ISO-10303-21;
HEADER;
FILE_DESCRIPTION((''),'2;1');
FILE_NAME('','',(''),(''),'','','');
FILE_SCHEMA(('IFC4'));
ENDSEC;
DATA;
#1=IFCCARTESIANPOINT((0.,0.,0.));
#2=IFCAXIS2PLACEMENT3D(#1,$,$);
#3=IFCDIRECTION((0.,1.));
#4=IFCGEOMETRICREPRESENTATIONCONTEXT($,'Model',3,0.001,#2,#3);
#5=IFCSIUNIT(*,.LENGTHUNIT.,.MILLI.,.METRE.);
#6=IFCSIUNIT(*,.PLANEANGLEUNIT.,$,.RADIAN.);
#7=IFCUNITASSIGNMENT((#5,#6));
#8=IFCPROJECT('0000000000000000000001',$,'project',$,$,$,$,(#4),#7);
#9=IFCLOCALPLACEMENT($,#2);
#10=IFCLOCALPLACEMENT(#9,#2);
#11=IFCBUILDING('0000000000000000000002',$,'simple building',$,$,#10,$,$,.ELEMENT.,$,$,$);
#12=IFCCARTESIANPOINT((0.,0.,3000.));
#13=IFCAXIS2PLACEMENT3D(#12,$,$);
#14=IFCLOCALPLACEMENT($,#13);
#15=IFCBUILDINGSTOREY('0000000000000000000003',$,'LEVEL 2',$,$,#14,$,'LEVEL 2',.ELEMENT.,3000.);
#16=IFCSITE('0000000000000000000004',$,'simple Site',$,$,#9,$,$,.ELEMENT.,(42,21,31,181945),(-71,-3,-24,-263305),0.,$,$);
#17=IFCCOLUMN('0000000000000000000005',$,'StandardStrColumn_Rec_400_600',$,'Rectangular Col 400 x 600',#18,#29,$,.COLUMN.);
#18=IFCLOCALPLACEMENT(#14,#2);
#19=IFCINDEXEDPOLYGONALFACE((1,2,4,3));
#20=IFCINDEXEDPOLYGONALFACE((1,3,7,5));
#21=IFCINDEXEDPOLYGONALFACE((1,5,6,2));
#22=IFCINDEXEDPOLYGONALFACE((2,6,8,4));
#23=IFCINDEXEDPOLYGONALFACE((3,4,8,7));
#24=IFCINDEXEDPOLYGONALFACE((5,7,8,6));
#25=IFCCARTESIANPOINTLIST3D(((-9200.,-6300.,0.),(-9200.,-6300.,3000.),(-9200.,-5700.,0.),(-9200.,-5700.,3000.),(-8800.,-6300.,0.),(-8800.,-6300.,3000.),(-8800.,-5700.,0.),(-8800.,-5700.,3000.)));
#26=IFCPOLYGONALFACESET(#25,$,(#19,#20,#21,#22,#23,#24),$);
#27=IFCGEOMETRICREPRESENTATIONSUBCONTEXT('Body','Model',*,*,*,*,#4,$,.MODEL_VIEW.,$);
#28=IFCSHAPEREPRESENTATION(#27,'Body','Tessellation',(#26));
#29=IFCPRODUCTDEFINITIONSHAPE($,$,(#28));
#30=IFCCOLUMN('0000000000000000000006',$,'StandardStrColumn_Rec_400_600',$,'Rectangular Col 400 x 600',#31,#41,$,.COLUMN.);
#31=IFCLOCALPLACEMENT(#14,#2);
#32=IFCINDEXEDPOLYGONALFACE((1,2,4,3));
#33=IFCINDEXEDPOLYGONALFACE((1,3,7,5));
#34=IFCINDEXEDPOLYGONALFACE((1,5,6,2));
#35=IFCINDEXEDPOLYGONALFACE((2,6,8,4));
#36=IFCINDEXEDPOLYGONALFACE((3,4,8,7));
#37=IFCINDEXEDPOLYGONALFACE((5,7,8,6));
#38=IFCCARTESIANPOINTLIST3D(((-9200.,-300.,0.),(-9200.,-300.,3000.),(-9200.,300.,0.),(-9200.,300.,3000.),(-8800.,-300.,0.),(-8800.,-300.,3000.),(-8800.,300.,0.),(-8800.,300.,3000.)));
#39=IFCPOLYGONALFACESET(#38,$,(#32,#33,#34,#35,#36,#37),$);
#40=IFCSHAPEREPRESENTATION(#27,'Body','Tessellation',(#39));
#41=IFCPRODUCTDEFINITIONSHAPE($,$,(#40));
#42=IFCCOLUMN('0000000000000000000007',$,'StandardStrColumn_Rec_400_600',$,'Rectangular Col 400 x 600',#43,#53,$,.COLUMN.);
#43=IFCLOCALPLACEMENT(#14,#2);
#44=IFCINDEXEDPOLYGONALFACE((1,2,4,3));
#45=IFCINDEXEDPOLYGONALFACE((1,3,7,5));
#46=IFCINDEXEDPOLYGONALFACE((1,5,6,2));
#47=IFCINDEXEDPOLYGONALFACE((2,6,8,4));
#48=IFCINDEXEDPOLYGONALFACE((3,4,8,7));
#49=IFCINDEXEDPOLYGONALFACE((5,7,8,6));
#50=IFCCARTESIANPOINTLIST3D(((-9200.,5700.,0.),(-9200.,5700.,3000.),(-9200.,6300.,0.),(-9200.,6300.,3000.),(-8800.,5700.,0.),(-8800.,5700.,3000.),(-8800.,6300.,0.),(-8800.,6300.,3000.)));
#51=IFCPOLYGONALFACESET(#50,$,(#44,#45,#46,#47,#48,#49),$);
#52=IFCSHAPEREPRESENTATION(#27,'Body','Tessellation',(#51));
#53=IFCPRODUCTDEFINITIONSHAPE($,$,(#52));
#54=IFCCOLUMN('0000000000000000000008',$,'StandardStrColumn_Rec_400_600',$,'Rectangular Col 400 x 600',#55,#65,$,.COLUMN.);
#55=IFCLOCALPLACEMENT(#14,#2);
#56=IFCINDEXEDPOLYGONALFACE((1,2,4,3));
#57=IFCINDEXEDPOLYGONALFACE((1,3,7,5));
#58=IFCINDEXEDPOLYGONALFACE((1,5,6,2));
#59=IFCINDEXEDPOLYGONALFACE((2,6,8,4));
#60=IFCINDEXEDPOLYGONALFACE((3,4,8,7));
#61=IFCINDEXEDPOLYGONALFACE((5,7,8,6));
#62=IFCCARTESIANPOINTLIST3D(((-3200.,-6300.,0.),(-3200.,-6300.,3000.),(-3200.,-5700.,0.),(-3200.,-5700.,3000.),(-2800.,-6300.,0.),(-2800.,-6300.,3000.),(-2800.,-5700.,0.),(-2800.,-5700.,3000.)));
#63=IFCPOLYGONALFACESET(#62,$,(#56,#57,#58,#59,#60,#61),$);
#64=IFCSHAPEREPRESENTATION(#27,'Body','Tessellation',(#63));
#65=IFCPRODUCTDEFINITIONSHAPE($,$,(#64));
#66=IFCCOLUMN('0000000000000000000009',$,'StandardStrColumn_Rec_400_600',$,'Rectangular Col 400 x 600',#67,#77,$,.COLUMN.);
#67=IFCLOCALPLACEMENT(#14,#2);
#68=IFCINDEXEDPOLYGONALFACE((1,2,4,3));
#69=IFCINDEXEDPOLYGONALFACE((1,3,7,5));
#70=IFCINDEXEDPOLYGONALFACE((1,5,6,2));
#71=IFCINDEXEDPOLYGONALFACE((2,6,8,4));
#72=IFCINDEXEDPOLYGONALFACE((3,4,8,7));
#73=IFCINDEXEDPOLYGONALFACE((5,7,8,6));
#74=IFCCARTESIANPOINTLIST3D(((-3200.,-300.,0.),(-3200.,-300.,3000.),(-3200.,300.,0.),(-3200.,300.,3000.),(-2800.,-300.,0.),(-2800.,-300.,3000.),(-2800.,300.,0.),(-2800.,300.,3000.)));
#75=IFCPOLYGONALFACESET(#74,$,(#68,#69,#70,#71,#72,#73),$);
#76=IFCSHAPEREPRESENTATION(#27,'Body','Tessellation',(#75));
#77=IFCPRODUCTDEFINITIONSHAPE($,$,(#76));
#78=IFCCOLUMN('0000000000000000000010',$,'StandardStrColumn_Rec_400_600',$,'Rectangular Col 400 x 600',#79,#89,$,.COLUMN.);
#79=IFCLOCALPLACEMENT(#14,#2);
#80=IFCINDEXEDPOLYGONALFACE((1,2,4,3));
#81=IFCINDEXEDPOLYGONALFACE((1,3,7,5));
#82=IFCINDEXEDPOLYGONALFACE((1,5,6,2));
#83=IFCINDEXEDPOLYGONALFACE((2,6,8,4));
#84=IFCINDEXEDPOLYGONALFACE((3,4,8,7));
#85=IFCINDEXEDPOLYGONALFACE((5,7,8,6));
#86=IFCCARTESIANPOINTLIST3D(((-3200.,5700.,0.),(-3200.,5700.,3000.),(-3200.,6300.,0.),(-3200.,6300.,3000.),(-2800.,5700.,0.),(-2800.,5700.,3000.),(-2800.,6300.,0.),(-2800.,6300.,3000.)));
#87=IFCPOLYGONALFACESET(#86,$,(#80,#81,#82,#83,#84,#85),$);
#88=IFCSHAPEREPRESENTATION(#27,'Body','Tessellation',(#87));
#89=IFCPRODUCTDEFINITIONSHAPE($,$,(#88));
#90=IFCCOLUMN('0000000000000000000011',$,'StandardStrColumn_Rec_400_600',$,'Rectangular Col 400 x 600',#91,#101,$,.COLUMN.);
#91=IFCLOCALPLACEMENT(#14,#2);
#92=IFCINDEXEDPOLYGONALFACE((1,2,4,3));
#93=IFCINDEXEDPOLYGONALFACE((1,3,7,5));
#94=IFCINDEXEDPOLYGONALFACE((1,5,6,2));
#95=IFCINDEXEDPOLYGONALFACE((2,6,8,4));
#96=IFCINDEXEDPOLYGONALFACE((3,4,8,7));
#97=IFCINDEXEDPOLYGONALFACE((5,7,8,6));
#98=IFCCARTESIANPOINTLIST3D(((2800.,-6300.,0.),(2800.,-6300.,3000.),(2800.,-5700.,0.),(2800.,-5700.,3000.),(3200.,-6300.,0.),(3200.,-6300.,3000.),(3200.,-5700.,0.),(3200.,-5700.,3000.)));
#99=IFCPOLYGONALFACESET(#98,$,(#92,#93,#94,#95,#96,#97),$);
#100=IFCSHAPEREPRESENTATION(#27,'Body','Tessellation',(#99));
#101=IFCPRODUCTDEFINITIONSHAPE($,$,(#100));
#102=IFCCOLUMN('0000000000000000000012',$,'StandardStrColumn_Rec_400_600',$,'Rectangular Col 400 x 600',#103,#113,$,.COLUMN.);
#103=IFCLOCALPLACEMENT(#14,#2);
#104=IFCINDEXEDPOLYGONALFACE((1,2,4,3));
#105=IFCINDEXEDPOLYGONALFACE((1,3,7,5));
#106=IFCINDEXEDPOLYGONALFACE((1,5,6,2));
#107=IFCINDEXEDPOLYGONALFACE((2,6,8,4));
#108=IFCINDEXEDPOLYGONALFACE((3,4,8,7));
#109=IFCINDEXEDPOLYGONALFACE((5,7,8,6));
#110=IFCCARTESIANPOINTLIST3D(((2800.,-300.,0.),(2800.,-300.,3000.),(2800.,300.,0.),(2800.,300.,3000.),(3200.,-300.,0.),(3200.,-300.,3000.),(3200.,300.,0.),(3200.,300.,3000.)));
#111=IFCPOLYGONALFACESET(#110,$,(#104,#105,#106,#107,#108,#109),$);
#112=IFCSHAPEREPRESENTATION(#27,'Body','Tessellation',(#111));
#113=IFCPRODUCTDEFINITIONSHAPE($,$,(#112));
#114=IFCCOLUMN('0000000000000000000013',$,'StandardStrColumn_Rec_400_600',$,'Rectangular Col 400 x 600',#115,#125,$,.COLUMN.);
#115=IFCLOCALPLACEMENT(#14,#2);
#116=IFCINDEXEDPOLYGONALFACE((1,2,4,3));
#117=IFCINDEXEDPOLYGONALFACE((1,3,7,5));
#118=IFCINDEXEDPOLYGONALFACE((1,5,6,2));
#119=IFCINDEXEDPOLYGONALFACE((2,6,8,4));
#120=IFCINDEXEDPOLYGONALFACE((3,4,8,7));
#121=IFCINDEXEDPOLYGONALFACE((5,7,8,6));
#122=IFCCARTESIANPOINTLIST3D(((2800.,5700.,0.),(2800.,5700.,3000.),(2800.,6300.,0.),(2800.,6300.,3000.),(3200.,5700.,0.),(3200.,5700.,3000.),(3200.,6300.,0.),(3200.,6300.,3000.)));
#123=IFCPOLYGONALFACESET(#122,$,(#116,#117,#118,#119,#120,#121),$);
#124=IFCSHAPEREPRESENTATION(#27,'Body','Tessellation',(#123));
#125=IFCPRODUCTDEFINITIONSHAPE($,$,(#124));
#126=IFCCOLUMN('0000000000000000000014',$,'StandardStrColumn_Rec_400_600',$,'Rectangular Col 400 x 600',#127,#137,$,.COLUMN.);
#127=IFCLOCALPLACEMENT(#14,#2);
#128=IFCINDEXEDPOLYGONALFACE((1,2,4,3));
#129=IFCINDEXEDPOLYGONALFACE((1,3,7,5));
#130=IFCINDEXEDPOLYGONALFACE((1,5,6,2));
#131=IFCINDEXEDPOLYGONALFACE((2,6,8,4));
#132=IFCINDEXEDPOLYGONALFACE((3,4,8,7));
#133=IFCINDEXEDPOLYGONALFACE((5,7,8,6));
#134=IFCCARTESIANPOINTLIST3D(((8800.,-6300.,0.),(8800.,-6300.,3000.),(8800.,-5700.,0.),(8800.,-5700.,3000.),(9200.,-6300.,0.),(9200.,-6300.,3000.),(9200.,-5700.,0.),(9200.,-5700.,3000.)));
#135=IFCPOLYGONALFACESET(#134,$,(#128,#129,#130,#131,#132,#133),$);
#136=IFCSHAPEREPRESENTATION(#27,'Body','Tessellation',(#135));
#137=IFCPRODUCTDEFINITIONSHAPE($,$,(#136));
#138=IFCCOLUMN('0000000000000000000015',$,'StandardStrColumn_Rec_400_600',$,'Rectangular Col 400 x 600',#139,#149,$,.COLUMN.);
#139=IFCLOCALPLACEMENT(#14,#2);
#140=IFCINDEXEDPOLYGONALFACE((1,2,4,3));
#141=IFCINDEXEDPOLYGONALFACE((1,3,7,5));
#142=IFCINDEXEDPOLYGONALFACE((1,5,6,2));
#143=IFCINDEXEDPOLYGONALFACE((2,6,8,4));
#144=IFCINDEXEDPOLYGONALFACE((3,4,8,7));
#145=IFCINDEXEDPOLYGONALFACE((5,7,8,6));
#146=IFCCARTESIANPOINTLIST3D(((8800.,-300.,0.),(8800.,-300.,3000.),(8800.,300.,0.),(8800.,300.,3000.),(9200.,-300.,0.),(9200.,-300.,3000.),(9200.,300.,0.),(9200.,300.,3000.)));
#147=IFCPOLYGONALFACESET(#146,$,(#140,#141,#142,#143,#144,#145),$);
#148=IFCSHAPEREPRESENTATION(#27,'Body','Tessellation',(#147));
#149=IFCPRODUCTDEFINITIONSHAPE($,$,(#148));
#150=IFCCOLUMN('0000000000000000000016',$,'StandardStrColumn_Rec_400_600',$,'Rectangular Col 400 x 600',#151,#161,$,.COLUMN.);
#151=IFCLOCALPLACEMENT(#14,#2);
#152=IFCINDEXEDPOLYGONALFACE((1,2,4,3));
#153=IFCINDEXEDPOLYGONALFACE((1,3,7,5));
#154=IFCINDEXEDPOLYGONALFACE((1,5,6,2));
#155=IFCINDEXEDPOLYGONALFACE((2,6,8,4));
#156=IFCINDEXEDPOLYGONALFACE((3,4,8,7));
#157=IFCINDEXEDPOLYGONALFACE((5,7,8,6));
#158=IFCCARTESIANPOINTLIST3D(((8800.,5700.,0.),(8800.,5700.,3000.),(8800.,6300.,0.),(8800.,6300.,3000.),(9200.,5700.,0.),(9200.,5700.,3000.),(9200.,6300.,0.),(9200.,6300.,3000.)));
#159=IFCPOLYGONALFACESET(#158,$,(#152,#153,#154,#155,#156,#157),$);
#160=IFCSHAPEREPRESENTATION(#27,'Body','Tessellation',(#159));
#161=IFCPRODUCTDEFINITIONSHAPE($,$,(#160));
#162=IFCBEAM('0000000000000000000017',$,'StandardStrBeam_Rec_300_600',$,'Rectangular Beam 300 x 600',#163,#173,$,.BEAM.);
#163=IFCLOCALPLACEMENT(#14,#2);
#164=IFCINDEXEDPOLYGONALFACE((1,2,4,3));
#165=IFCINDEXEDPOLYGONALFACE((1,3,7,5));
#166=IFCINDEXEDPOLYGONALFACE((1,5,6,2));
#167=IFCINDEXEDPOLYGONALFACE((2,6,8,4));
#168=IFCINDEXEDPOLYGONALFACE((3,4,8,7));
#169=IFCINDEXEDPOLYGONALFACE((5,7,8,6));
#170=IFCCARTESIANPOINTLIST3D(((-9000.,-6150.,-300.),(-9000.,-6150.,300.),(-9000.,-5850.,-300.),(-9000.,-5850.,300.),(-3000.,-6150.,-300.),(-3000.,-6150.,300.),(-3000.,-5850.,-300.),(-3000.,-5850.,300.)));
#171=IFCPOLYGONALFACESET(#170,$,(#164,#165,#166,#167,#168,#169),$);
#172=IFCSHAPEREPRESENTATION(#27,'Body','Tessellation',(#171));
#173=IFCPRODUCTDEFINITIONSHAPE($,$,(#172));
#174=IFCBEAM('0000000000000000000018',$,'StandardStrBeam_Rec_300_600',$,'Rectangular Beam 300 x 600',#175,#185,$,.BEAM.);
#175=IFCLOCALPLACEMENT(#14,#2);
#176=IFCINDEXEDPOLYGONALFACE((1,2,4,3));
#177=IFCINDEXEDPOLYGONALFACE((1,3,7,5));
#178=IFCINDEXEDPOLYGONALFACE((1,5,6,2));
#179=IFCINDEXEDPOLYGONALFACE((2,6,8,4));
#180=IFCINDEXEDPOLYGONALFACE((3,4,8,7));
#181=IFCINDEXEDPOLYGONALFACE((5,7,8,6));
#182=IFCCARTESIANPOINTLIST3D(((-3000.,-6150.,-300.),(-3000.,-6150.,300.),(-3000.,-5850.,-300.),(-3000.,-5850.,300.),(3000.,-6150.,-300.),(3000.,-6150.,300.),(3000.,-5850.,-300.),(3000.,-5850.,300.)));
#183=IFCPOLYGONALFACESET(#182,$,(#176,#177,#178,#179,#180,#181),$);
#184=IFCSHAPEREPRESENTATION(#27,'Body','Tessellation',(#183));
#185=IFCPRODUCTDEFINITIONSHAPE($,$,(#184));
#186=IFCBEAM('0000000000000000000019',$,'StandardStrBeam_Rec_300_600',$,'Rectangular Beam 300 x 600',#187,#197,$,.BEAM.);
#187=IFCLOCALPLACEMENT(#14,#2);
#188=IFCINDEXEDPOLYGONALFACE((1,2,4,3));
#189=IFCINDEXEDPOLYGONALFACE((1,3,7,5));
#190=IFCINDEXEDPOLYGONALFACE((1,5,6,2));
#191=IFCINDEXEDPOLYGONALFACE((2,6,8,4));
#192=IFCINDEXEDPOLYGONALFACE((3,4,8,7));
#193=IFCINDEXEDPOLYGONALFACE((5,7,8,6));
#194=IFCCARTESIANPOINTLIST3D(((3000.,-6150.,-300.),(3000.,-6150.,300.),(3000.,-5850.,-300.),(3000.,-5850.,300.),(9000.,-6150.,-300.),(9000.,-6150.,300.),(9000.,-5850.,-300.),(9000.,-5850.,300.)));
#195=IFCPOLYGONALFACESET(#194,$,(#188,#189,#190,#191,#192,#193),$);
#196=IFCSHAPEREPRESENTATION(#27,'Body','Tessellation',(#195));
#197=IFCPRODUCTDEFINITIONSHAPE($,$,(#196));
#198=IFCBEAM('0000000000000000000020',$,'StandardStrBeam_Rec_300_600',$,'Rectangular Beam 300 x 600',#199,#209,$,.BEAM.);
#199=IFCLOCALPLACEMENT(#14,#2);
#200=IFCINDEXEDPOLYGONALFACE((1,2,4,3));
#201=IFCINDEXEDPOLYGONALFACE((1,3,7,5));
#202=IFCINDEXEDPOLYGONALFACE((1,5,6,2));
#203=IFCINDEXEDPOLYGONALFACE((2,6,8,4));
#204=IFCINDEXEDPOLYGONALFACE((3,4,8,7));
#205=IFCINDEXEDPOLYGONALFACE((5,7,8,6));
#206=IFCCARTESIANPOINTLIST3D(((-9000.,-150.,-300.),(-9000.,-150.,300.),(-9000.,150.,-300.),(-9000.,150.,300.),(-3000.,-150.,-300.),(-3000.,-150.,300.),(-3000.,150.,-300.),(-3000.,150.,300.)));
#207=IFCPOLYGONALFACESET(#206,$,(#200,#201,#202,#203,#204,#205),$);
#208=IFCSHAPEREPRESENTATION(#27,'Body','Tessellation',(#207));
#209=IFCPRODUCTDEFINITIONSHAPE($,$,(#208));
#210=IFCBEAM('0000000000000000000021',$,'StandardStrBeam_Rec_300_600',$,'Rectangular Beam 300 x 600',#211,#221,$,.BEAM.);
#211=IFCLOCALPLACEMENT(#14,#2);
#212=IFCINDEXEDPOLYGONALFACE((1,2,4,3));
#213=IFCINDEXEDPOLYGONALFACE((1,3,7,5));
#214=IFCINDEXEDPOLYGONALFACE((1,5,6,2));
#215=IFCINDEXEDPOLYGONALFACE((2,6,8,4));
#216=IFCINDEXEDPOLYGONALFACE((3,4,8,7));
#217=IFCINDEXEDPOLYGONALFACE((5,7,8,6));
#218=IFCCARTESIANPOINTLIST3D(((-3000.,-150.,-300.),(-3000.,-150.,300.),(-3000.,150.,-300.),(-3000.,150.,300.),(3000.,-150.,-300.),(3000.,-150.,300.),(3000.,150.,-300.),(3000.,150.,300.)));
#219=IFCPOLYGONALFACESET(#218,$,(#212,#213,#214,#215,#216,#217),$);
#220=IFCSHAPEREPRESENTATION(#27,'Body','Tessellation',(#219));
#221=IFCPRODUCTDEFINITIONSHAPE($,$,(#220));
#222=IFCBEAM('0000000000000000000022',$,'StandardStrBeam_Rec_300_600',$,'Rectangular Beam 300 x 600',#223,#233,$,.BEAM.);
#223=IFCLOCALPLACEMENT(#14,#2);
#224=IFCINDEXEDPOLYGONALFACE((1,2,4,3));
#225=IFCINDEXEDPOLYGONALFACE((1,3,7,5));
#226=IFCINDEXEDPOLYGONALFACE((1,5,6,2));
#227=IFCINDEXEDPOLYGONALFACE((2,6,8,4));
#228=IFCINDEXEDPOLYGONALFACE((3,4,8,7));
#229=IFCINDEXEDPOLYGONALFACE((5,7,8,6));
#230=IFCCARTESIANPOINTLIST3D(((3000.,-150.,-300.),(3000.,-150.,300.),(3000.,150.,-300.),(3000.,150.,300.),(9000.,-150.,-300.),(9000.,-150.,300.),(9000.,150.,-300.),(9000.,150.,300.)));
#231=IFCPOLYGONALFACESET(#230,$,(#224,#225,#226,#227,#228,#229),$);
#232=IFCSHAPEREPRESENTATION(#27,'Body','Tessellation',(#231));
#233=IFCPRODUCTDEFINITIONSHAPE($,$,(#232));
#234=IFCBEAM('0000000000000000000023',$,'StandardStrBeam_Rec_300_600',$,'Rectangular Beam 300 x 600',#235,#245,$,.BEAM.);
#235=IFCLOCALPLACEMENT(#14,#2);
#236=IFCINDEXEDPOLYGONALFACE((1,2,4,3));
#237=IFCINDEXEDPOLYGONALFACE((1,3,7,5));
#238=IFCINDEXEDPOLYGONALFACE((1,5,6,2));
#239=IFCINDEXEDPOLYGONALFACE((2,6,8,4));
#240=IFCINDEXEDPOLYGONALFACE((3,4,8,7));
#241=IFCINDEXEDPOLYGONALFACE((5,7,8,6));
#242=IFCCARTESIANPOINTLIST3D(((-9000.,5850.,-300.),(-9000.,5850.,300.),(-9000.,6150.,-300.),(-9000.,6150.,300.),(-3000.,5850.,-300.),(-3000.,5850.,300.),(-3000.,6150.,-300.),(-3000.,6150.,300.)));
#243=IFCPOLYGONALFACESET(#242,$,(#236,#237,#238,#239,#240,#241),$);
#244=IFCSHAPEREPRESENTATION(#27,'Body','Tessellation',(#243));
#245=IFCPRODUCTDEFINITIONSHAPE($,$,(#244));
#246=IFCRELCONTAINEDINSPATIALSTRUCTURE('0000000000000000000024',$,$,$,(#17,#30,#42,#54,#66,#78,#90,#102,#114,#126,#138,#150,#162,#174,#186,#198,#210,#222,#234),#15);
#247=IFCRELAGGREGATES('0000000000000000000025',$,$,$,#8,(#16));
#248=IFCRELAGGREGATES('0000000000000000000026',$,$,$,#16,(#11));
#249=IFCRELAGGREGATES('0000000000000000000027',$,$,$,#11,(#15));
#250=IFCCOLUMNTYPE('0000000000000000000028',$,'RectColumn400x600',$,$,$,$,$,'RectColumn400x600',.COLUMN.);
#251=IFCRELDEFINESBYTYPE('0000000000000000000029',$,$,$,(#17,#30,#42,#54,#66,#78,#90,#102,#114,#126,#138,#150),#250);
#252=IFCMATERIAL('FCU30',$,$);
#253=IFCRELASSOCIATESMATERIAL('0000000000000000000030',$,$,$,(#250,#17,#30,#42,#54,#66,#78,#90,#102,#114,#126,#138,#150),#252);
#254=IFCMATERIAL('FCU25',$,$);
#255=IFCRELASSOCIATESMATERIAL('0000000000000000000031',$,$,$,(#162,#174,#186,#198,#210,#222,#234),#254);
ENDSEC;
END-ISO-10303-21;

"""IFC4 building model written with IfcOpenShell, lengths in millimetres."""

from ifc_helpers import new_model, si_unit, direction, frame, origin, origin_with_axes, origin_2d_with_axis, place, context, subcontext, project, spatial, rectangle, extrude, material, material_profile, profile_set, profile_usage, type_object, element, save


model = new_model("IFC4")

# Units and contexts
model_context = context("Model", 3, precision=0.001, world=origin(), true_north=direction((0.0, 1.0)))
body_context = subcontext(model_context, "Body", "Model", "MODEL_VIEW")
ifc_project = project(units=[si_unit("LENGTHUNIT", "METRE", prefix="MILLI"), si_unit("PLANEANGLEUNIT", "RADIAN")], contexts=[model_context])

# Site, building, storey
site_placement = place(None, origin())
site = spatial("IfcSite", under=ifc_project, at=site_placement, Name="simple Site", CompositionType="ELEMENT", RefLatitude=(42, 21, 31, 181945), RefLongitude=(-71, -3, -24, -263305), RefElevation=0.0)
building_placement = place(site_placement, origin())
building = spatial("IfcBuilding", under=site, at=building_placement, Name="simple building", CompositionType="ELEMENT")
storey_placement = place(None, frame((0.0, 0.0, 3000.0)))
storey = spatial("IfcBuildingStorey", under=building, at=storey_placement, Name="LEVEL 2", LongName="LEVEL 2", CompositionType="ELEMENT", Elevation=3000.0)

# Columns
ifc_material_1 = material(Name="FCU30")
ifc_material_profile_1 = material_profile(ifc_material_1, rectangle(XDim=400.0, YDim=600.0, at=origin_2d_with_axis()))
ifc_profile_set_1 = profile_set([ifc_material_profile_1])
ifc_profile_usage_1 = profile_usage(ifc_profile_set_1, cardinal=10)
column_type = type_object("IfcColumnType", Name="RectColumn400x600", ElementType="RectColumn400x600", PredefinedType="COLUMN", material=ifc_profile_usage_1)
for number, where, z_axis, x_axis, name in (
    (1, (-9000.0, -6000.0, 3000.0), (0.0, 0.0, 1.0), (1.0, 0.0, 0.0), "StandardStrColumn_Rec_400_600"),
    (2, (-9000.0, 0.0, 3000.0), (0.0, 0.0, 1.0), (1.0, 0.0, 0.0), "StandardStrColumn_Rec_400_600"),
    (3, (-9000.0, 6000.0, 3000.0), (0.0, 0.0, 1.0), (1.0, 0.0, 0.0), "StandardStrColumn_Rec_400_600"),
    (4, (-3000.0, -6000.0, 3000.0), (0.0, 0.0, 1.0), (1.0, 0.0, 0.0), "StandardStrColumn_Rec_400_600"),
    (5, (-3000.0, 0.0, 3000.0), (0.0, 0.0, 1.0), (1.0, 0.0, 0.0), "StandardStrColumn_Rec_400_600"),
    (6, (-3000.0, 6000.0, 3000.0), (0.0, 0.0, 1.0), (1.0, 0.0, 0.0), "StandardStrColumn_Rec_400_600"),
    (7, (3000.0, -6000.0, 3000.0), (0.0, 0.0, 1.0), (1.0, 0.0, 0.0), "StandardStrColumn_Rec_400_600"),
    (8, (3000.0, 0.0, 3000.0), (0.0, 0.0, 1.0), (1.0, 0.0, 0.0), "StandardStrColumn_Rec_400_600"),
    (9, (3000.0, 6000.0, 3000.0), (0.0, 0.0, 1.0), (1.0, 0.0, 0.0), "StandardStrColumn_Rec_400_600"),
    (10, (9000.0, -6000.0, 3000.0), (0.0, 0.0, 1.0), (1.0, 0.0, 0.0), "StandardStrColumn_Rec_400_600"),
    (11, (9000.0, 0.0, 3000.0), (0.0, 0.0, 1.0), (1.0, 0.0, 0.0), "StandardStrColumn_Rec_400_600"),
    (12, (9000.0, 6000.0, 3000.0), (0.0, 0.0, 1.0), (1.0, 0.0, 0.0), "StandardStrColumn_Rec_400_600"),
):
    element("IfcColumn", number, at=place(None, frame(where, z_axis=z_axis, x_axis=x_axis)), inside=storey, type_object=column_type, material=ifc_profile_usage_1, Name=name, ObjectType="Rectangular Col 400 x 600", PredefinedType="COLUMN", context=body_context, shape_type="SweptSolid", body=[
        extrude(rectangle(XDim=400.0, YDim=600.0, at=origin_2d_with_axis()), origin_with_axes(), (0.0, 0.0, 1.0), 3000.0),
    ])

# Beams
ifc_material_2 = material(Name="FCU25")
ifc_material_profile_2 = material_profile(ifc_material_2, rectangle(XDim=300.0, YDim=600.0, at=origin_2d_with_axis()))
ifc_profile_set_2 = profile_set([ifc_material_profile_2])
ifc_profile_usage_2 = profile_usage(ifc_profile_set_2, cardinal=10)
for number, where, z_axis, x_axis, name in (
    (13, (-9000.0, -6000.0, 3000.0), (1.0, 0.0, 0.0), (0.0, -1.0, 0.0), "StandardStrBeam_Rec_300_600"),
    (14, (-3000.0, -6000.0, 3000.0), (1.0, 0.0, 0.0), (0.0, -1.0, 0.0), "StandardStrBeam_Rec_300_600"),
    (15, (3000.0, -6000.0, 3000.0), (1.0, 0.0, 0.0), (0.0, -1.0, 0.0), "StandardStrBeam_Rec_300_600"),
    (16, (-9000.0, 0.0, 3000.0), (1.0, 0.0, 0.0), (0.0, -1.0, 0.0), "StandardStrBeam_Rec_300_600"),
    (17, (-3000.0, 0.0, 3000.0), (1.0, 0.0, 0.0), (0.0, -1.0, 0.0), "StandardStrBeam_Rec_300_600"),
    (18, (3000.0, 0.0, 3000.0), (1.0, 0.0, 0.0), (0.0, -1.0, 0.0), "StandardStrBeam_Rec_300_600"),
    (19, (-9000.0, 6000.0, 3000.0), (1.0, 0.0, 0.0), (0.0, -1.0, 0.0), "StandardStrBeam_Rec_300_600"),
):
    element("IfcBeam", number, at=place(None, frame(where, z_axis=z_axis, x_axis=x_axis)), inside=storey, material=ifc_profile_usage_2, Name=name, ObjectType="Rectangular Beam 300 x 600", PredefinedType="BEAM", context=body_context, shape_type="SweptSolid", body=[
        extrude(rectangle(XDim=300.0, YDim=600.0, at=origin_2d_with_axis()), origin_with_axes(), (0.0, 0.0, 1.0), 6000.0),
    ])

save(model, "model.ifc")
